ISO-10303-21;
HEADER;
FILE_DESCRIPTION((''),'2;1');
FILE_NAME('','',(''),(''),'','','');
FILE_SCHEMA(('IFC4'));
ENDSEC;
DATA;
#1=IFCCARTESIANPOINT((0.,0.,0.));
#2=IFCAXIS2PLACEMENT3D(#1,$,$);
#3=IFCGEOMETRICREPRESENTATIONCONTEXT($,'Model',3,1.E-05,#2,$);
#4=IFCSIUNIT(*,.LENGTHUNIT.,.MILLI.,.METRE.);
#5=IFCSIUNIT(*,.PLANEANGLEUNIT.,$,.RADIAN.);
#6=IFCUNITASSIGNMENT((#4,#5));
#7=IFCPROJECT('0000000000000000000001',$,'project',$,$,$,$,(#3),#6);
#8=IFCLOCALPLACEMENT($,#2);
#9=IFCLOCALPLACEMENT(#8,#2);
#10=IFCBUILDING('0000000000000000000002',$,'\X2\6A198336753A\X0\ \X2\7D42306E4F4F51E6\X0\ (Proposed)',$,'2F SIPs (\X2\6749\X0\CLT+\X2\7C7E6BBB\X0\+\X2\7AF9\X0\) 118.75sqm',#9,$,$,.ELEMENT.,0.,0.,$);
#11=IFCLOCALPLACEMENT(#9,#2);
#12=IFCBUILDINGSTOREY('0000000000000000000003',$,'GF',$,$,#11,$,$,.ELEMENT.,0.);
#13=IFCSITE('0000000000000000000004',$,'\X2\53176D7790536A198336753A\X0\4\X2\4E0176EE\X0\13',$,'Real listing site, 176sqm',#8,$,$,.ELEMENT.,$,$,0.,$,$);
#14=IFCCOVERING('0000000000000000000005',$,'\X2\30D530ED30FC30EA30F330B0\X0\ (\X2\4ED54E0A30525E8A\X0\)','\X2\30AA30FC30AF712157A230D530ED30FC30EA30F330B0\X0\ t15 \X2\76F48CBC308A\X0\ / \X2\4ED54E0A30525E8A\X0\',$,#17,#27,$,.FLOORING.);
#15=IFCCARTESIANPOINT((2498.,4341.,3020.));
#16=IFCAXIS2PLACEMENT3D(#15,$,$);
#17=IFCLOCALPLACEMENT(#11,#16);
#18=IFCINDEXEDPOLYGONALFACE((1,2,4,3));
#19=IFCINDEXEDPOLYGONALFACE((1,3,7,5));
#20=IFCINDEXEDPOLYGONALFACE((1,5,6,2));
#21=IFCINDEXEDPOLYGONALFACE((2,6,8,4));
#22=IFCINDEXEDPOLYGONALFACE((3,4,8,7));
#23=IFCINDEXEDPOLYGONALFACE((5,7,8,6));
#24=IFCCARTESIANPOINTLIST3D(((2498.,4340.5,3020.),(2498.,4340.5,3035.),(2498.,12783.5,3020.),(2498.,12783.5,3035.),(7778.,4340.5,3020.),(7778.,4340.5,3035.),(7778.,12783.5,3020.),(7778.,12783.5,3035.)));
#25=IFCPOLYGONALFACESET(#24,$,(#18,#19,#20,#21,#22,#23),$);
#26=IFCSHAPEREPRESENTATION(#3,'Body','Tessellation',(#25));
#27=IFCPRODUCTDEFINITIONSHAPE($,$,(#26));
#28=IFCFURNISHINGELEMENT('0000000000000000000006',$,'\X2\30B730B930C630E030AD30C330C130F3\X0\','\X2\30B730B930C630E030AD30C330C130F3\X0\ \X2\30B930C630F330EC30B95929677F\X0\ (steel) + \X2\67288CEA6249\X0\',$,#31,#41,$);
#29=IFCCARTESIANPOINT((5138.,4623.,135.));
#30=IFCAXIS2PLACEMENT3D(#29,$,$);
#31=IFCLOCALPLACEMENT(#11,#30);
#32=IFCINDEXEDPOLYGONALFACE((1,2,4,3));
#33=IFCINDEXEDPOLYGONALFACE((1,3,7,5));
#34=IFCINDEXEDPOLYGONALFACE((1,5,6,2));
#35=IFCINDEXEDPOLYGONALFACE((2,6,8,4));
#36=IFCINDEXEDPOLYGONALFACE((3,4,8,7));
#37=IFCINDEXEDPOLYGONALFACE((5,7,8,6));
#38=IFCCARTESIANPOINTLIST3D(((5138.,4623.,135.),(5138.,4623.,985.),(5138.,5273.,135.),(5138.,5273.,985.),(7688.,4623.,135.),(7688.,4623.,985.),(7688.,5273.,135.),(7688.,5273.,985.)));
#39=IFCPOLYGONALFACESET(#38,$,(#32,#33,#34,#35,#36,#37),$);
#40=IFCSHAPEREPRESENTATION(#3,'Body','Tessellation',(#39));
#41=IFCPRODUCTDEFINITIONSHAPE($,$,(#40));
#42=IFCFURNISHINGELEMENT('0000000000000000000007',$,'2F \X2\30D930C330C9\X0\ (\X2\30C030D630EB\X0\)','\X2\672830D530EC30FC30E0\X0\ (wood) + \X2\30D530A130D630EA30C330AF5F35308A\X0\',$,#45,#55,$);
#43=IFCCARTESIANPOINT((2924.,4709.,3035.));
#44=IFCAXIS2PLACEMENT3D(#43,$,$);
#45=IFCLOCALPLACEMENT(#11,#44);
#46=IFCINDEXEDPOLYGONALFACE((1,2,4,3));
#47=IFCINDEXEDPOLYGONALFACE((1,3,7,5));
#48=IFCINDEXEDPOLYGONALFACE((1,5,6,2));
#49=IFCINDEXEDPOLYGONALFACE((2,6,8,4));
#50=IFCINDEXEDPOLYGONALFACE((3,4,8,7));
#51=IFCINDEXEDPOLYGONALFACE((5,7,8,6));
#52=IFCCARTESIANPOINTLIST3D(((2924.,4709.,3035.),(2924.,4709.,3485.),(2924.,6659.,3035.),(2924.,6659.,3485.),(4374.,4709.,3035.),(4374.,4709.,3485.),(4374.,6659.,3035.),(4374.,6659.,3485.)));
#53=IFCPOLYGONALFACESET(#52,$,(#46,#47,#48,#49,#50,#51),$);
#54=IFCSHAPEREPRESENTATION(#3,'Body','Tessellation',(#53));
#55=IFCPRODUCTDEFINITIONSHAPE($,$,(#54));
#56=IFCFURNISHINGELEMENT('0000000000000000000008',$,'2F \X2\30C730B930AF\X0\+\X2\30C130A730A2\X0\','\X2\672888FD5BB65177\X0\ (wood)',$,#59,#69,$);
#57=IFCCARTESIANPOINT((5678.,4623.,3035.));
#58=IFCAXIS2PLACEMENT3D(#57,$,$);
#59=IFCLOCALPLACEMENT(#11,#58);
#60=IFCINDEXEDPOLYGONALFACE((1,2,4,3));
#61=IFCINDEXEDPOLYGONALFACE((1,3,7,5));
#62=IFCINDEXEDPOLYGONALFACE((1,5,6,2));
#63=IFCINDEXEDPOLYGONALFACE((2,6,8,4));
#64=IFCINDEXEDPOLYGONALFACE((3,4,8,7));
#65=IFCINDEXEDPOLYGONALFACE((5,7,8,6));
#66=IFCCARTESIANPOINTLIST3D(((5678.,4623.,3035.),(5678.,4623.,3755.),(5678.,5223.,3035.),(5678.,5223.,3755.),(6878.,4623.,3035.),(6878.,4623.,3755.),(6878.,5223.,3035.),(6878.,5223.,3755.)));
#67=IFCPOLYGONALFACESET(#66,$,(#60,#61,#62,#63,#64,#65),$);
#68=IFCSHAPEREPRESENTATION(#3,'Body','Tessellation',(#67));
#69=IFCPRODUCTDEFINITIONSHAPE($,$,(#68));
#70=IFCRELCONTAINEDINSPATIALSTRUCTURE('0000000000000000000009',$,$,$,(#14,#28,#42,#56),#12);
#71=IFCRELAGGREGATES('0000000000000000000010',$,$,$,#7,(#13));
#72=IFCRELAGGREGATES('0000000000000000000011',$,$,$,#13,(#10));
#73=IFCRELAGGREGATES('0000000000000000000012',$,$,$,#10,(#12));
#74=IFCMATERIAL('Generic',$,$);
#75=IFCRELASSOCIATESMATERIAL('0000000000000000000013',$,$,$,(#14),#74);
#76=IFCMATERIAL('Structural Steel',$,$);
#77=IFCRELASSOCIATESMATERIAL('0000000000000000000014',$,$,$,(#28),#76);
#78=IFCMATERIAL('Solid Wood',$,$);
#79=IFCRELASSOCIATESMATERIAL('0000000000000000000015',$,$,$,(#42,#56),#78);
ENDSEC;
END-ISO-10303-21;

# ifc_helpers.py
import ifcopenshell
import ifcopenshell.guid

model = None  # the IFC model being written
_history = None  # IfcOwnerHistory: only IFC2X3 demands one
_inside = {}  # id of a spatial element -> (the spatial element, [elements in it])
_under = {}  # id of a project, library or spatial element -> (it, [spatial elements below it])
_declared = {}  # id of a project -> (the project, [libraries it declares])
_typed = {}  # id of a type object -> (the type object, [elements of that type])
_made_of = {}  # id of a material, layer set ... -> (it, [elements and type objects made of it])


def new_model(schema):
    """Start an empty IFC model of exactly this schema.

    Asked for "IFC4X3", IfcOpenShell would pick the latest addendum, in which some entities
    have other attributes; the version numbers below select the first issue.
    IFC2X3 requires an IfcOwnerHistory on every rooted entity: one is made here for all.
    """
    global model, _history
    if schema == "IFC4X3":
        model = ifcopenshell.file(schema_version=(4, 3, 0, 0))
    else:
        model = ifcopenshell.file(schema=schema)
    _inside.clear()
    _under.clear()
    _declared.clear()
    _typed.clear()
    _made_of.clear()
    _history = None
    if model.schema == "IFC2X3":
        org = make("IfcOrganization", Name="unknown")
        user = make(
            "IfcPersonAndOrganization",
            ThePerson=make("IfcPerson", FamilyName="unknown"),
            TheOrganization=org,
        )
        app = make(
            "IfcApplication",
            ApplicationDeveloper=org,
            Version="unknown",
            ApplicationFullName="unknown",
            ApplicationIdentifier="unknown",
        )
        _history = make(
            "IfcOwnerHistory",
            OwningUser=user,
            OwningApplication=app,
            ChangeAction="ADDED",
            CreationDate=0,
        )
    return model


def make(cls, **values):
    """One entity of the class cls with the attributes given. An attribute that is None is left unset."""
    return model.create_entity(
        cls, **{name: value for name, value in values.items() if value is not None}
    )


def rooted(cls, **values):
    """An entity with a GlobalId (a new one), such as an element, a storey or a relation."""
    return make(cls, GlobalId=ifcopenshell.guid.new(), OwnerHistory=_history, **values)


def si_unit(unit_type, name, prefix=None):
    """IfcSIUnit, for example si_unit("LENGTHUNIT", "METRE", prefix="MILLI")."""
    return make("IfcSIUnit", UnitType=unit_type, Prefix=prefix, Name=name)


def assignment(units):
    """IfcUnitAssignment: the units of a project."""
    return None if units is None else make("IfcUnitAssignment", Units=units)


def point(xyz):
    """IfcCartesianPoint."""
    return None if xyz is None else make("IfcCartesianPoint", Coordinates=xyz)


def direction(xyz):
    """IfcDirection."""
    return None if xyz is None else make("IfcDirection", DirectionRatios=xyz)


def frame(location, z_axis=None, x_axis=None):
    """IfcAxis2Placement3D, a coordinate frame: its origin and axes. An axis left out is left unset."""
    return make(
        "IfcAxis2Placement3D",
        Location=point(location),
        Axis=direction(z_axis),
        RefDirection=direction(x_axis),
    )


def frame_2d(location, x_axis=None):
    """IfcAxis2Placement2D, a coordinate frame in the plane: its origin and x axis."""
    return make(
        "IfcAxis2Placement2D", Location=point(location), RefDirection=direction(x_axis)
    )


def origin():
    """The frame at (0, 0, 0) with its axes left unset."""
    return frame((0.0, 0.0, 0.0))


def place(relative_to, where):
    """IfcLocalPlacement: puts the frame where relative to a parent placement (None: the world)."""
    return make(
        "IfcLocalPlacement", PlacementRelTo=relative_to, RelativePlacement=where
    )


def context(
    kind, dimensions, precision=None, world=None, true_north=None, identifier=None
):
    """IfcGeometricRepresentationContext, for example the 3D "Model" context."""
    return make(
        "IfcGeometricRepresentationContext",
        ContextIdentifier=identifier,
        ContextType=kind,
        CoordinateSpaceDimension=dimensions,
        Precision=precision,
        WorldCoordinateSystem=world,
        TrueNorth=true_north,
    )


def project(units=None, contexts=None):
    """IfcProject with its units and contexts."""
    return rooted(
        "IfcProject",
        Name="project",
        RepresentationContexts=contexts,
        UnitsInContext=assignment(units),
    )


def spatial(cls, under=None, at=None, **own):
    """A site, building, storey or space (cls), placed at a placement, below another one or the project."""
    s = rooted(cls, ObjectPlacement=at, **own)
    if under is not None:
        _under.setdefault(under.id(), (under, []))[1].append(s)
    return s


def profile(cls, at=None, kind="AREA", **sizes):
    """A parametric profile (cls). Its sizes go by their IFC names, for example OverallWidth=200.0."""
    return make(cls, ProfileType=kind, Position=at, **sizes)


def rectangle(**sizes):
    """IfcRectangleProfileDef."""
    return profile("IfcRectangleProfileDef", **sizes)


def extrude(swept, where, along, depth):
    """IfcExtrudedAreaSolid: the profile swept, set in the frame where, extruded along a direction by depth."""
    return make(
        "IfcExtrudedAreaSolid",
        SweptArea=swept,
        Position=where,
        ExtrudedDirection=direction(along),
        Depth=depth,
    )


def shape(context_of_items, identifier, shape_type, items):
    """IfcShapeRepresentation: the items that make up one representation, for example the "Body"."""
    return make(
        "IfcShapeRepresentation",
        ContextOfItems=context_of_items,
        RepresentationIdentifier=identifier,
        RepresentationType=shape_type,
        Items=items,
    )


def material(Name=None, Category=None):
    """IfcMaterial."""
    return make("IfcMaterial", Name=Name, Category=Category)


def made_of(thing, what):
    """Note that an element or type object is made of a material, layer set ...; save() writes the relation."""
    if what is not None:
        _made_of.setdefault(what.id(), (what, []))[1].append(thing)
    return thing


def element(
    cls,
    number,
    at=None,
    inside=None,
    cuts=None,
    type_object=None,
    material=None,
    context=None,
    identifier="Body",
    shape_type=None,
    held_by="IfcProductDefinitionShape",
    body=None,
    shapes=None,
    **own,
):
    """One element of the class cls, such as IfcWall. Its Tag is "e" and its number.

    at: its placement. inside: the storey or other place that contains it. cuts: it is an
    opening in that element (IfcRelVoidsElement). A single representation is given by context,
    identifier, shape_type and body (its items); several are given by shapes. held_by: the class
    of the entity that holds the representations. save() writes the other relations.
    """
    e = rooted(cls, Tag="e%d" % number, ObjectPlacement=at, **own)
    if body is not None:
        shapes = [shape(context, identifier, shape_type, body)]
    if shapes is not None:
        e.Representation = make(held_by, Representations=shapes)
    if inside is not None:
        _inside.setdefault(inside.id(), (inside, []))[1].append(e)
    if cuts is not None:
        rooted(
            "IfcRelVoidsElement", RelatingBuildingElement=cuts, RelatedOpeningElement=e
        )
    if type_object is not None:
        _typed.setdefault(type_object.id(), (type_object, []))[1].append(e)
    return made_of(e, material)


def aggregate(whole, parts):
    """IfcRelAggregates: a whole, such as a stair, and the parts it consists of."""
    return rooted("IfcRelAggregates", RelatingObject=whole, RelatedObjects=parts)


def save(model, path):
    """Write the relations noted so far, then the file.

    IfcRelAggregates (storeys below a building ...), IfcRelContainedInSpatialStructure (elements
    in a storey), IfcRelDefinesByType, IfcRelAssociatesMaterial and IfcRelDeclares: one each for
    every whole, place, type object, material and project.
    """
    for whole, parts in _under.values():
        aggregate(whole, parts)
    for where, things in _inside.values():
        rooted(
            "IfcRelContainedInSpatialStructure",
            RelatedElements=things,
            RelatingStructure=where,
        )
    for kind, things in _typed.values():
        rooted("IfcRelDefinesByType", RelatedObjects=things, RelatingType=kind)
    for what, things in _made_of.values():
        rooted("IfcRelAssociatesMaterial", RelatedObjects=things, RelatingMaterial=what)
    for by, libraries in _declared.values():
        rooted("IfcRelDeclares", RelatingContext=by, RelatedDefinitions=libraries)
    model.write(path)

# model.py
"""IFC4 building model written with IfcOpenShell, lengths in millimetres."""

from ifc_helpers import new_model, si_unit, frame, frame_2d, origin, place, context, project, spatial, rectangle, extrude, material, element, save


model = new_model("IFC4")

# Units and contexts
model_context = context("Model", 3, precision=1e-05, world=origin())
ifc_project = project(units=[si_unit("LENGTHUNIT", "METRE", prefix="MILLI"), si_unit("PLANEANGLEUNIT", "RADIAN")], contexts=[model_context])

# Site, building, storey
site_placement = place(None, origin())
site = spatial("IfcSite", under=ifc_project, at=site_placement, Name="北海道標茶町4丁目13", ObjectType="Real listing site, 176sqm", CompositionType="ELEMENT", RefElevation=0.0)
building_placement = place(site_placement, origin())
building = spatial("IfcBuilding", under=site, at=building_placement, Name="標茶町 終の住処 (Proposed)", ObjectType="2F SIPs (杉CLT+籾殻+竹) 118.75sqm", CompositionType="ELEMENT", ElevationOfRefHeight=0.0, ElevationOfTerrain=0.0)
storey_placement = place(building_placement, origin())
storey = spatial("IfcBuildingStorey", under=building, at=storey_placement, Name="GF", CompositionType="ELEMENT", Elevation=0.0)

# Shared definitions
ifc_material_1 = material(Name="Solid Wood")

# Shared definitions
ifc_material_2 = material(Name="Generic")

# Shared definitions
ifc_material_3 = material(Name="Structural Steel")

# Covering
covering_placement = place(storey_placement, frame((2498.0, 4341.0, 3020.0)))
element("IfcCovering", 1, at=covering_placement, inside=storey, material=ifc_material_2, Name="フローリング (仕上げ床)", Description="オーク無垢フローリング t15 直貼り / 仕上げ床", PredefinedType="FLOORING", context=model_context, shape_type="SweptSolid", body=[
    extrude(rectangle(XDim=5280.0, YDim=8443.0, at=frame_2d((2640.0, 4221.0))), frame((2498.0, 4341.0, 3020.0)), (0.0, 0.0, 1.0), 15.0),
])

# Furnishing elements
furnishing_1_placement = place(storey_placement, frame((5138.0, 4623.0, 135.0)))
element("IfcFurnishingElement", 2, at=furnishing_1_placement, inside=storey, material=ifc_material_3, Name="システムキッチン", Description="システムキッチン ステンレス天板 (steel) + 木質扉", context=model_context, shape_type="SweptSolid", body=[
    extrude(rectangle(XDim=2550.0, YDim=650.0, at=frame_2d((1275.0, 325.0))), frame((5138.0, 4623.0, 135.0)), (0.0, 0.0, 1.0), 850.0),
])
furnishing_2_placement = place(storey_placement, frame((2924.0, 4709.0, 3035.0)))
element("IfcFurnishingElement", 3, at=furnishing_2_placement, inside=storey, material=ifc_material_1, Name="2F ベッド (ダブル)", Description="木フレーム (wood) + ファブリック張り", context=model_context, shape_type="SweptSolid", body=[
    extrude(rectangle(XDim=1450.0, YDim=1950.0, at=frame_2d((725.0, 975.0))), frame((2924.0, 4709.0, 3035.0)), (0.0, 0.0, 1.0), 450.0),
])
furnishing_3_placement = place(storey_placement, frame((5678.0, 4623.0, 3035.0)))
element("IfcFurnishingElement", 4, at=furnishing_3_placement, inside=storey, material=ifc_material_1, Name="2F デスク+チェア", Description="木製家具 (wood)", context=model_context, shape_type="SweptSolid", body=[
    extrude(rectangle(XDim=1200.0, YDim=600.0, at=frame_2d((600.0, 300.0))), frame((5678.0, 4623.0, 3035.0)), (0.0, 0.0, 1.0), 720.0),
])

save(model, "model.ifc")
